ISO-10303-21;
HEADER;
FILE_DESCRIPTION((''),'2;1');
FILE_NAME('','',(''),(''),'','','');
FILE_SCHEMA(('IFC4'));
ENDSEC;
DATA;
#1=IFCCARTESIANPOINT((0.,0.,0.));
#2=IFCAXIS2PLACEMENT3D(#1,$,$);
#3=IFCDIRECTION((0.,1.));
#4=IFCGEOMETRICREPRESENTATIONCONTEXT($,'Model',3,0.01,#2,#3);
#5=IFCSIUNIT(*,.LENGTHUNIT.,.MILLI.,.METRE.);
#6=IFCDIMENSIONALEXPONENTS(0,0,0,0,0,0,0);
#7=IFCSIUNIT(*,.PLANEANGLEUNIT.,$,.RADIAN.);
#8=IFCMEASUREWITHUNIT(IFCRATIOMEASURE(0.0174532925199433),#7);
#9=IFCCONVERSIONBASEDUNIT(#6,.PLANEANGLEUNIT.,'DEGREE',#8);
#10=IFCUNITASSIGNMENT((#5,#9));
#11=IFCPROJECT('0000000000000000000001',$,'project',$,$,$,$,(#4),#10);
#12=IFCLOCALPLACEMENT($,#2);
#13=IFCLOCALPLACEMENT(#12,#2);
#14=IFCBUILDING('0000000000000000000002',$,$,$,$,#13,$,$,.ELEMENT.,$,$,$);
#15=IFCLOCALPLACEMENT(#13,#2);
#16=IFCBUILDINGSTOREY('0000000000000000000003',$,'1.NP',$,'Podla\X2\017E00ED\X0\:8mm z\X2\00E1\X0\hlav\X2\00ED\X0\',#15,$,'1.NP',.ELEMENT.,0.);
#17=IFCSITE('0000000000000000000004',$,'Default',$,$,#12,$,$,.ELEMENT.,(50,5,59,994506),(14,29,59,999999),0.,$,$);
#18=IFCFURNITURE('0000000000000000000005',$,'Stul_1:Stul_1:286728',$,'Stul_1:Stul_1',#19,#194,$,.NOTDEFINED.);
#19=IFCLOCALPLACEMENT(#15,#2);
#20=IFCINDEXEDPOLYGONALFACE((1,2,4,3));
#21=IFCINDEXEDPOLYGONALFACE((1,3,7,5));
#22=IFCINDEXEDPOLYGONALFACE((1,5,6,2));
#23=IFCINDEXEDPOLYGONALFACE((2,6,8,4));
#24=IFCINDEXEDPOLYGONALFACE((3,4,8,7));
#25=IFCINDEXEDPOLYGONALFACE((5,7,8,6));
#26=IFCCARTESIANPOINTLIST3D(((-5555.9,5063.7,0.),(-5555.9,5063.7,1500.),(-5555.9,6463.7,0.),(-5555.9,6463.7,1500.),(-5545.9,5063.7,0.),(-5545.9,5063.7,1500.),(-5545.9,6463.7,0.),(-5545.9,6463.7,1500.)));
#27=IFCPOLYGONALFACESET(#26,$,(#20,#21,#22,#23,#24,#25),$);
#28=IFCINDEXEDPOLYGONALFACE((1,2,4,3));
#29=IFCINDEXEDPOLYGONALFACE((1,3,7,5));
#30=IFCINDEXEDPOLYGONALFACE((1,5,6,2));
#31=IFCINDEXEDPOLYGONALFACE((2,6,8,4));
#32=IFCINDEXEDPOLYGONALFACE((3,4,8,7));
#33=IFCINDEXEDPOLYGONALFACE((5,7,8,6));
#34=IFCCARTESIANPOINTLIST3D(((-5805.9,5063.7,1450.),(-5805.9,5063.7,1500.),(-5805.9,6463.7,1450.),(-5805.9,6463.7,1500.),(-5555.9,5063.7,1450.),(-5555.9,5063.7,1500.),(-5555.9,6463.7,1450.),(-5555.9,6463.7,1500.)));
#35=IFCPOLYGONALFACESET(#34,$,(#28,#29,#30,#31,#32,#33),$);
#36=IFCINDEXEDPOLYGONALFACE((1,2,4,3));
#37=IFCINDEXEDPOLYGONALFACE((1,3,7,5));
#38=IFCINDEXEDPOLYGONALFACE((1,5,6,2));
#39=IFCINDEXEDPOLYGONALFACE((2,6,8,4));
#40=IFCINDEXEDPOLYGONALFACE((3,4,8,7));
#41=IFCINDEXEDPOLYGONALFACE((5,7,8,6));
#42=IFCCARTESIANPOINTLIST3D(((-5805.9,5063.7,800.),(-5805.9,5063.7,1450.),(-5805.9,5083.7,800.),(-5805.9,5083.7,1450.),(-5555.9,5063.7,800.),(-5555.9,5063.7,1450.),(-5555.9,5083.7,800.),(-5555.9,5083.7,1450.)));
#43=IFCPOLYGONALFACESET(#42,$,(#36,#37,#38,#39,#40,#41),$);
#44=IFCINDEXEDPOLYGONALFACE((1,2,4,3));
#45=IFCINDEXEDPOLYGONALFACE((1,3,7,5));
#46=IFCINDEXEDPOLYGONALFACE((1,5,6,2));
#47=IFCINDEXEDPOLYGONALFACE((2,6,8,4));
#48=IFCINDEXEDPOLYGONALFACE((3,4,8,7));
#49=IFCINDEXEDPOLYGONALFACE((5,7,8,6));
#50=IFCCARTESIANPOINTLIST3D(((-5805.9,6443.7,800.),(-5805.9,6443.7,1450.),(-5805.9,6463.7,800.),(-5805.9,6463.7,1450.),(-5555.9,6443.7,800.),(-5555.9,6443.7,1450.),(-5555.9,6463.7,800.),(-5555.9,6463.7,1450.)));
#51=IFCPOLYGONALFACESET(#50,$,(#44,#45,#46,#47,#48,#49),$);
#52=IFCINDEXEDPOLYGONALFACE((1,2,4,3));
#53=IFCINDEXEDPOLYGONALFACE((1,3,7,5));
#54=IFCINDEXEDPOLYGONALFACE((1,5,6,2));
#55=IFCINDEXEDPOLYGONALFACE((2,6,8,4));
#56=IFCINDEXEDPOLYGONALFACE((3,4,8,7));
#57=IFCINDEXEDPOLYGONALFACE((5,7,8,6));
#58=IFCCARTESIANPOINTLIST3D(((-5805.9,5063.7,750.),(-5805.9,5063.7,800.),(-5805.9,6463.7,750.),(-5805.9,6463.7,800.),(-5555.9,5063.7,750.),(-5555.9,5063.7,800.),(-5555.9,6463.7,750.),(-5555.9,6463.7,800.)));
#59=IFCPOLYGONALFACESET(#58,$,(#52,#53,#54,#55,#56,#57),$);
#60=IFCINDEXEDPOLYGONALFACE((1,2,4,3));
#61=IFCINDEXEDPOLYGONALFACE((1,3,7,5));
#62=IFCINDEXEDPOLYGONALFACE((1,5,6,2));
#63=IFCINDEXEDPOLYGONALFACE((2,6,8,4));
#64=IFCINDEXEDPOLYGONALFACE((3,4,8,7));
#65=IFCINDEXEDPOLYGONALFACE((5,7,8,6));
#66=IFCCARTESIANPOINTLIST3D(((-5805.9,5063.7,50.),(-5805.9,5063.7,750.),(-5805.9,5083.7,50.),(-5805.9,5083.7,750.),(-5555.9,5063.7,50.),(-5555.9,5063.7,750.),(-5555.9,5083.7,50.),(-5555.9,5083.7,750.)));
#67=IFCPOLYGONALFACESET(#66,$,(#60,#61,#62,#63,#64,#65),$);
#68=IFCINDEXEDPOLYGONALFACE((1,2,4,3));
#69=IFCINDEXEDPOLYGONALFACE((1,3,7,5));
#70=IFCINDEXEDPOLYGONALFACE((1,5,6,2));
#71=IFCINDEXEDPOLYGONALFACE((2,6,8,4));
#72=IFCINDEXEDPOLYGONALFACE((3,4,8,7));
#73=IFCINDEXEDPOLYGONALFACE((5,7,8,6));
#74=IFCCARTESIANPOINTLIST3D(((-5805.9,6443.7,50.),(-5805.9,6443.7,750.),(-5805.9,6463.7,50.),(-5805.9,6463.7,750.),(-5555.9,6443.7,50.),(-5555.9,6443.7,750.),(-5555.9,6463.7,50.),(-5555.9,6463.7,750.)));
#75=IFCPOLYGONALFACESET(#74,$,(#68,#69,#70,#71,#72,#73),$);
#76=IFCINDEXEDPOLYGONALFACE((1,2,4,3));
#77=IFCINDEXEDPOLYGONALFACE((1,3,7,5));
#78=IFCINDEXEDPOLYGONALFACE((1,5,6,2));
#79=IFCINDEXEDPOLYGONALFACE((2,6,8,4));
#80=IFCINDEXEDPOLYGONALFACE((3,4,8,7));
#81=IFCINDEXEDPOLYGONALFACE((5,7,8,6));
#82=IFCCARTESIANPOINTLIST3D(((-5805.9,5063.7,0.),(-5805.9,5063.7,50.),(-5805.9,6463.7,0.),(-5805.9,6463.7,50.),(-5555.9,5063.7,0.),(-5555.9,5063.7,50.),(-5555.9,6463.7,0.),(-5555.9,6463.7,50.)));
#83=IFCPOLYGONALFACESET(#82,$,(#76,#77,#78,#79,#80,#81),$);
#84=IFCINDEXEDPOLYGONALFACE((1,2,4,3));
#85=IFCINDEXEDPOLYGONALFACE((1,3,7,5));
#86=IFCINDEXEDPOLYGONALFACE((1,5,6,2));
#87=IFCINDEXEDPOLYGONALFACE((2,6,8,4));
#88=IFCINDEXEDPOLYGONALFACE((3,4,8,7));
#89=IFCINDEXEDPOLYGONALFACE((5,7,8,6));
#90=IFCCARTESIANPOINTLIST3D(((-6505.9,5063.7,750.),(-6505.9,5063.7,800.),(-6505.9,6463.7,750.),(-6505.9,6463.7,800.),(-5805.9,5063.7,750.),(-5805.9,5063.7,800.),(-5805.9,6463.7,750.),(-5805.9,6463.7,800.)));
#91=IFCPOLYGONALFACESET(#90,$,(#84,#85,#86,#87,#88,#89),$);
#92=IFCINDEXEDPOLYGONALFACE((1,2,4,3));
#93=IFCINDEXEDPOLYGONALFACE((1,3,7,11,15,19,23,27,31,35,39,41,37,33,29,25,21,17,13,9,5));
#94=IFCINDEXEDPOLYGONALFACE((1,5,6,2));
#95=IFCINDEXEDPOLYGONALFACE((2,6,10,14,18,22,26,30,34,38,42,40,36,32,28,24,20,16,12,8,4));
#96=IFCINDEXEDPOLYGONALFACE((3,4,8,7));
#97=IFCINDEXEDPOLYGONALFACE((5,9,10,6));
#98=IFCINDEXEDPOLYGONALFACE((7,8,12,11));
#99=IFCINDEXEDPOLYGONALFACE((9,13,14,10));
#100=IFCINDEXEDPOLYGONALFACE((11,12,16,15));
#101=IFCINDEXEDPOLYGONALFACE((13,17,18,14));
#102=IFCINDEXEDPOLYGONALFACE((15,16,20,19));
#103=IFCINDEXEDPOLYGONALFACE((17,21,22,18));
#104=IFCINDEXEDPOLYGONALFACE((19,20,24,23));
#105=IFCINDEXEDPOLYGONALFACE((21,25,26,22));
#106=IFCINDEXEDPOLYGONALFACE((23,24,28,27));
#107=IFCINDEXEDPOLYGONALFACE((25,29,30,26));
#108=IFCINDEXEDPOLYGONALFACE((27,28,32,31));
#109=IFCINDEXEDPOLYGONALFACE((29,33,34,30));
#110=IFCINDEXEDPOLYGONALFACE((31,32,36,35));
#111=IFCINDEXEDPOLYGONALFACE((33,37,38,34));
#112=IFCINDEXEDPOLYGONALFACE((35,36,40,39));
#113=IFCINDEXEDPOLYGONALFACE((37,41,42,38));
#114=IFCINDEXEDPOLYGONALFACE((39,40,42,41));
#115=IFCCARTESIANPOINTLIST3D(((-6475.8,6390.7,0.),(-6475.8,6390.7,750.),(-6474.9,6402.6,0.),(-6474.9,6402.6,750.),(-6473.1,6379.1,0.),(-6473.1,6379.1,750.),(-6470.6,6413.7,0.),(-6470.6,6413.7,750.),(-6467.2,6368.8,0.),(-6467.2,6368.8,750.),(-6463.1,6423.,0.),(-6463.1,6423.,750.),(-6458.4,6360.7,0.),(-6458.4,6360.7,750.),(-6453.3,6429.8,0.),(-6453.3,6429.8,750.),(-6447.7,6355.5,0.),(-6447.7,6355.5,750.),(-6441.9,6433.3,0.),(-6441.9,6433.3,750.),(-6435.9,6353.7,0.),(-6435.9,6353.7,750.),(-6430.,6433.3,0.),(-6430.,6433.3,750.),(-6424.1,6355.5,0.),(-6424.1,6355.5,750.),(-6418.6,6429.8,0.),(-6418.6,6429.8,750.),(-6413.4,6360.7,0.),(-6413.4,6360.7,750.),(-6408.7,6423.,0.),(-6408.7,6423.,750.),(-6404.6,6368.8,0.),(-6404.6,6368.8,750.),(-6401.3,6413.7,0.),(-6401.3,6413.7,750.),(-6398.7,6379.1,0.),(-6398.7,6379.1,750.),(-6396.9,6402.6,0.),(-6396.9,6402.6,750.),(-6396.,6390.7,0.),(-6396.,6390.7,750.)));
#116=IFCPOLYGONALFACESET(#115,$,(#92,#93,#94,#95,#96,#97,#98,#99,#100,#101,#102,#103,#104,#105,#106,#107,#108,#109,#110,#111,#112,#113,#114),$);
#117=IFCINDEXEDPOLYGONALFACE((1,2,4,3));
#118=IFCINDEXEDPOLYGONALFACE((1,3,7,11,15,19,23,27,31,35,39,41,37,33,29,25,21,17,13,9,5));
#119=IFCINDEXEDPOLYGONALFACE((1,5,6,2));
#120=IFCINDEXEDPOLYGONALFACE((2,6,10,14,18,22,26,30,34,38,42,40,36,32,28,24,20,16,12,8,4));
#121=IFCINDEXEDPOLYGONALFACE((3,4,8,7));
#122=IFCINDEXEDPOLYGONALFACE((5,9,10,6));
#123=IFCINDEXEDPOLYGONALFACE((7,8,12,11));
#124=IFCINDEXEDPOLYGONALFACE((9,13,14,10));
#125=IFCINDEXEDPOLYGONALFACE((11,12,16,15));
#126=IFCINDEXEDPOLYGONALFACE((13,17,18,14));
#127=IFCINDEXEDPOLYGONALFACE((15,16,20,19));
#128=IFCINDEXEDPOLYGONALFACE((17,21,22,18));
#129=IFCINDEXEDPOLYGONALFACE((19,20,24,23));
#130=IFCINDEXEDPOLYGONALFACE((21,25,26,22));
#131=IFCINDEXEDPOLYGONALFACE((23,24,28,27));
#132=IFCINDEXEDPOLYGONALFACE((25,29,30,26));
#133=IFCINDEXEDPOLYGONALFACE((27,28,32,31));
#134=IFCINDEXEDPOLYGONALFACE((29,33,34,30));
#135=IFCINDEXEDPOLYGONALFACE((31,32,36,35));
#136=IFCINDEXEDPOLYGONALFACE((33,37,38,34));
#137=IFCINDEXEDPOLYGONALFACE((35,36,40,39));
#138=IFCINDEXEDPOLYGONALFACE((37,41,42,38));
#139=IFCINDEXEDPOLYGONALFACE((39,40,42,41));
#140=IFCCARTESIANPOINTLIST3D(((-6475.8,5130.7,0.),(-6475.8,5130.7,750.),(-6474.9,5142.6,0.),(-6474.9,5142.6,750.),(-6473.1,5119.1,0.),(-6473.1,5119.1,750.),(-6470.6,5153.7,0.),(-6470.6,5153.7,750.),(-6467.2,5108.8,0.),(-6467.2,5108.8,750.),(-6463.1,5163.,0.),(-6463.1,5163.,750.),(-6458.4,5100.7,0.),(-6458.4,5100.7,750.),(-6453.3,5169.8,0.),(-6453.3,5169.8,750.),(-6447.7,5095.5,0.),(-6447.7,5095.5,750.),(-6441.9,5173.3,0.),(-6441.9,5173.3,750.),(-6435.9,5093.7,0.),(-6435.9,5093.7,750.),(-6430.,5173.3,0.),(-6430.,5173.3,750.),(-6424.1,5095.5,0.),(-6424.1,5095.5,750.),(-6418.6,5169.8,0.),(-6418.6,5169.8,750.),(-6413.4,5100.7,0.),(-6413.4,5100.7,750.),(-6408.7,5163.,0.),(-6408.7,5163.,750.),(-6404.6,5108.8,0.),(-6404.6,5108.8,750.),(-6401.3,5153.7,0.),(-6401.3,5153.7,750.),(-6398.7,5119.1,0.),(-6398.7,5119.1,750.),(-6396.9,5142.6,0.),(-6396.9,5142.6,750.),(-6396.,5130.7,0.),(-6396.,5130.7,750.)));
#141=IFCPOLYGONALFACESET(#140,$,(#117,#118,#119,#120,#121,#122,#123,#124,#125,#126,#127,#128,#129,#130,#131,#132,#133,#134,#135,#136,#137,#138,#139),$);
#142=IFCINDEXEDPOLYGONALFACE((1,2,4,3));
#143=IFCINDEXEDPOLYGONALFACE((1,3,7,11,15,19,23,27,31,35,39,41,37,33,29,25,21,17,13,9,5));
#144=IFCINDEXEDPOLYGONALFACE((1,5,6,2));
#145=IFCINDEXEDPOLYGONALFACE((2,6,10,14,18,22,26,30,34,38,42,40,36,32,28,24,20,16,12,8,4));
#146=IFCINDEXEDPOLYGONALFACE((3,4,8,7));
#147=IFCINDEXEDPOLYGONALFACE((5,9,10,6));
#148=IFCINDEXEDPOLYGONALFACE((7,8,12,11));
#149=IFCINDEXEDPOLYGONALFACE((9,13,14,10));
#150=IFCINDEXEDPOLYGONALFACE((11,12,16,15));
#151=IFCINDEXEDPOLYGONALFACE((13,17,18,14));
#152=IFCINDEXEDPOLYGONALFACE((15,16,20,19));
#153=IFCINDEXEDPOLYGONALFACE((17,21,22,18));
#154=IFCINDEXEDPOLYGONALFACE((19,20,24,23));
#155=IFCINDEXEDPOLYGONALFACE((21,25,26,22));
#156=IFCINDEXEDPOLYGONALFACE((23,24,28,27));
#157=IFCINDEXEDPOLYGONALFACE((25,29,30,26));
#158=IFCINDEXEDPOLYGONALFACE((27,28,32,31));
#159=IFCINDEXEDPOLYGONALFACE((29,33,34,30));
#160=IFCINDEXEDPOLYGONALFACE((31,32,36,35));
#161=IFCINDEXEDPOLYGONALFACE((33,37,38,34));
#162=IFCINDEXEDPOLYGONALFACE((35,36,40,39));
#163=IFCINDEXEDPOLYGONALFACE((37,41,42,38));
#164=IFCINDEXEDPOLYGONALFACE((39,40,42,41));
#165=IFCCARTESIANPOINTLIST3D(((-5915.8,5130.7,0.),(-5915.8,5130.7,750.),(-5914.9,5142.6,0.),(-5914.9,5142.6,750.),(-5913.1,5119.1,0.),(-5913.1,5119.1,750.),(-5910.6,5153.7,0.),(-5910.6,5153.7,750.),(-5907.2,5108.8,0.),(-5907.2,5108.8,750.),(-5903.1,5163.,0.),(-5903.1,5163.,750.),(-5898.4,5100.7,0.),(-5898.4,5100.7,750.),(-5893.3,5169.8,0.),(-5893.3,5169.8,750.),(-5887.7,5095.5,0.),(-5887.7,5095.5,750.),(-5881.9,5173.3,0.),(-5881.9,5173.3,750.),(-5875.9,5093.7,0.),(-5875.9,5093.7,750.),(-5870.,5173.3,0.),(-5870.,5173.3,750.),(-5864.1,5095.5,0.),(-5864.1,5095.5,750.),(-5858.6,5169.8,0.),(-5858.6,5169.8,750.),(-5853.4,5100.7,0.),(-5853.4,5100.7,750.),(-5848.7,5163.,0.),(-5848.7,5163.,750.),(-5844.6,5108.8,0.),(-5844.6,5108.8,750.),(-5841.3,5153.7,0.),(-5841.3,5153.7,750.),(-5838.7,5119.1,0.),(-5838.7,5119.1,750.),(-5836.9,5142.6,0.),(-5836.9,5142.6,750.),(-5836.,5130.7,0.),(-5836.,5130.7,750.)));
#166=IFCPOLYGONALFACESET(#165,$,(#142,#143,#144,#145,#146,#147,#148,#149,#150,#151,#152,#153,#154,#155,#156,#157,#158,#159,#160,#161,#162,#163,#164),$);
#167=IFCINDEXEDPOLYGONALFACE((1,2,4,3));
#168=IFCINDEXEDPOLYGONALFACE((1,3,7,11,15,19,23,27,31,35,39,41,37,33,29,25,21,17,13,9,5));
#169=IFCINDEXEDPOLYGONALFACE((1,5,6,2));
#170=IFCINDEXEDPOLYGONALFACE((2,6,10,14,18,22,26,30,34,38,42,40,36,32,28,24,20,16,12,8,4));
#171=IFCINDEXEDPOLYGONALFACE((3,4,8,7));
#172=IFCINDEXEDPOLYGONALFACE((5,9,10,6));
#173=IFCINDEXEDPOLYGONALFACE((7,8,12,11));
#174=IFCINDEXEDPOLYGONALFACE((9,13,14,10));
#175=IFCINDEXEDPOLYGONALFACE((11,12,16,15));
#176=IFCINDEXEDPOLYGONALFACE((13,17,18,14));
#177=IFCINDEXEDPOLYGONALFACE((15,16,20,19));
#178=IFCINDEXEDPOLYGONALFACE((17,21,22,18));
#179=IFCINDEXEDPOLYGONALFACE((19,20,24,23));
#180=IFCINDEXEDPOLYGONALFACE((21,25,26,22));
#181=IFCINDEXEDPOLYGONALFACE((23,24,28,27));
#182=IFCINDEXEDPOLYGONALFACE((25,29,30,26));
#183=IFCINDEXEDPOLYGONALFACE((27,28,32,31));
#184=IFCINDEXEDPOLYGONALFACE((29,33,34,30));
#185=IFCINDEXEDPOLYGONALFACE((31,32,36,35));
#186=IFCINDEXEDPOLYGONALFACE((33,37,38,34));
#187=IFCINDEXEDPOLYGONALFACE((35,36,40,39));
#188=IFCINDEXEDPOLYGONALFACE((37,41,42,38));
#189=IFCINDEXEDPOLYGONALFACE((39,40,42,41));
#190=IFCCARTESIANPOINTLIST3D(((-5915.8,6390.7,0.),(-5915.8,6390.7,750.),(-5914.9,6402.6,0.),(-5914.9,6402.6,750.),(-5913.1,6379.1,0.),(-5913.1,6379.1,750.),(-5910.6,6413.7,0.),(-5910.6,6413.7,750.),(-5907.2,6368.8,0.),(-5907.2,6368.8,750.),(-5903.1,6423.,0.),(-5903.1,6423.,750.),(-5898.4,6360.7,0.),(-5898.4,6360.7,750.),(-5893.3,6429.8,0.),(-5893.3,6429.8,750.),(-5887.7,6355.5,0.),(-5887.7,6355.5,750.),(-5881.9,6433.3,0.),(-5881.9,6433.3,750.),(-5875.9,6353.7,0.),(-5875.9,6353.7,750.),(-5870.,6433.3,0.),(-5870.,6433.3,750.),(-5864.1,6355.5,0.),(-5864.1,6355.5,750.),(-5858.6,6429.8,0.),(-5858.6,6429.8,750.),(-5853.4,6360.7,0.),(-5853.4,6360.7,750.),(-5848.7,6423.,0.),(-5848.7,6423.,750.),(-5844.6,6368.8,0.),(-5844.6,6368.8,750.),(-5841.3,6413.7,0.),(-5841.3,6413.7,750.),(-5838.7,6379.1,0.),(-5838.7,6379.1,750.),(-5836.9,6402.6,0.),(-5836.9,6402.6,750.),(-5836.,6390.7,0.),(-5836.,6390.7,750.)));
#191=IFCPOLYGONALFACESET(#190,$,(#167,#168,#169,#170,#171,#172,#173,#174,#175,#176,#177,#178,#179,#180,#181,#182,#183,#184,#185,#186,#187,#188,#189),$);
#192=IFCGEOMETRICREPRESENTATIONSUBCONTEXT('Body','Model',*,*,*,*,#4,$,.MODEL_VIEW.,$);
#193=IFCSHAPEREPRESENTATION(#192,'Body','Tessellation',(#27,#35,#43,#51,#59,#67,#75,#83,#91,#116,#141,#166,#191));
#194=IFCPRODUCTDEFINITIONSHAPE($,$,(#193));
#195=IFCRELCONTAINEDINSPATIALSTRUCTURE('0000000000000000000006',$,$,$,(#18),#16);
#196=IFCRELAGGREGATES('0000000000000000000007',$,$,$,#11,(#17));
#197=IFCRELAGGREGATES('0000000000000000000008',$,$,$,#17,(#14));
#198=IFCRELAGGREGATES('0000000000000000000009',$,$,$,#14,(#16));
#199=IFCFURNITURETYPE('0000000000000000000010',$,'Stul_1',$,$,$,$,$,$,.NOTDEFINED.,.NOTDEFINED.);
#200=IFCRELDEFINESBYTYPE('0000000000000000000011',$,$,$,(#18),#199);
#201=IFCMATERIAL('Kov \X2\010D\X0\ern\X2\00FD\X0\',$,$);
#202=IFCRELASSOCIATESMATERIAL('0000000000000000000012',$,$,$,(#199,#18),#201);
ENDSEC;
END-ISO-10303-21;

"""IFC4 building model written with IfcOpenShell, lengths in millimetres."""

from ifc_helpers import new_model, entity, si_unit, converted_unit, direction, frame, frame_2d, origin, origin_2d_with_axis, place, context, subcontext, project, spatial, rectangle, circle, extrude, source, transform, mapped, material, type_object, type_shapes, element, save


model = new_model("IFC4")

# Units and contexts
model_context = context("Model", 3, precision=0.01, world=origin(), true_north=direction((0.0, 1.0)))
body_context = subcontext(model_context, "Body", "Model", "MODEL_VIEW")
ifc_project = project(units=[si_unit("LENGTHUNIT", "METRE", prefix="MILLI"), converted_unit("PLANEANGLEUNIT", "DEGREE", entity("IfcRatioMeasure", 0.0174532925199433), si_unit("PLANEANGLEUNIT", "RADIAN"), dimensions=[0, 0, 0, 0, 0, 0, 0])], contexts=[model_context])

# Site, building, storey
site_placement = place(None, origin())
site = spatial("IfcSite", under=ifc_project, at=site_placement, Name="Default", CompositionType="ELEMENT", RefLatitude=(50, 5, 59, 994506), RefLongitude=(14, 29, 59, 999999), RefElevation=0.0)
building_placement = place(site_placement, origin())
building = spatial("IfcBuilding", under=site, at=building_placement, CompositionType="ELEMENT")
storey_placement = place(building_placement, origin())
storey = spatial("IfcBuildingStorey", under=building, at=storey_placement, Name="1.NP", ObjectType="Podlaží:8mm záhlaví", LongName="1.NP", CompositionType="ELEMENT", Elevation=0.0)

# Furniture
ifc_material_1 = material(Name="Kov černý")
furniture_type = type_object("IfcFurnitureType", Name="Stul_1", AssemblyPlace="NOTDEFINED", PredefinedType="NOTDEFINED", material=ifc_material_1)
shared_shape_1 = source(origin(), body_context, "Body", "SweptSolid", [
    extrude(rectangle(XDim=1400.0, YDim=10.0, at=origin_2d_with_axis()), frame((0.0, 605.0, 0.0), z_axis=(0.0, 0.0, 1.0), x_axis=(-1.0, 0.0, 0.0)), (0.0, 0.0, 1.0), 1500.0),
    extrude(rectangle(XDim=1400.0, YDim=250.0, at=frame_2d((0.0, 0.0), x_axis=(1.0, 0.0))), frame((0.0, 475.0, 1450.0), z_axis=(0.0, 0.0, 1.0), x_axis=(-1.0, 0.0, 0.0)), (0.0, 0.0, 1.0), 50.0),
    extrude(rectangle(XDim=20.0, YDim=250.0, at=origin_2d_with_axis()), frame((690.0, 475.0, 800.0), z_axis=(0.0, 0.0, 1.0), x_axis=(-1.0, 0.0, 0.0)), (0.0, 0.0, 1.0), 650.0),
    extrude(rectangle(XDim=20.0, YDim=250.0, at=frame_2d((0.0, 0.0), x_axis=(1.0, 0.0))), frame((-690.0, 475.0, 800.0), z_axis=(0.0, 0.0, 1.0), x_axis=(-1.0, 0.0, 0.0)), (0.0, 0.0, 1.0), 650.0),
    extrude(rectangle(XDim=1400.0, YDim=250.0, at=origin_2d_with_axis()), frame((0.0, 475.0, 750.0), z_axis=(0.0, 0.0, 1.0), x_axis=(-1.0, 0.0, 0.0)), (0.0, 0.0, 1.0), 50.0),
    extrude(rectangle(XDim=20.0, YDim=250.0, at=origin_2d_with_axis()), frame((690.0, 475.0, 50.0), z_axis=(0.0, 0.0, 1.0), x_axis=(-1.0, 0.0, 0.0)), (0.0, 0.0, 1.0), 700.0),
    extrude(rectangle(XDim=20.0, YDim=250.0, at=frame_2d((0.0, 0.0), x_axis=(1.0, 0.0))), frame((-690.0, 475.0, 50.0), z_axis=(0.0, 0.0, 1.0), x_axis=(-1.0, 0.0, 0.0)), (0.0, 0.0, 1.0), 700.0),
    extrude(rectangle(XDim=1400.0, YDim=250.0, at=origin_2d_with_axis()), frame((0.0, 475.0, 0.0), z_axis=(0.0, 0.0, 1.0), x_axis=(-1.0, 0.0, 0.0)), (0.0, 0.0, 1.0), 50.0),
    extrude(rectangle(XDim=1400.0, YDim=700.0, at=origin_2d_with_axis()), frame((0.0, 0.0, 750.0), z_axis=(0.0, 0.0, 1.0), x_axis=(-1.0, 0.0, 0.0)), (0.0, 0.0, 1.0), 50.0),
    extrude(circle(Radius=40.0, at=frame_2d((0.0, 0.0), x_axis=(1.0, 0.0))), frame((-630.0, -280.0, 0.0)), (0.0, 0.0, 1.0), 750.0),
    extrude(circle(Radius=40.0, at=frame_2d((0.0, 0.0), x_axis=(1.0, 0.0))), frame((630.0, -280.0, 0.0)), (0.0, 0.0, 1.0), 750.0),
    extrude(circle(Radius=40.0, at=frame_2d((0.0, 0.0), x_axis=(1.0, 0.0))), frame((630.0, 280.0, 0.0)), (0.0, 0.0, 1.0), 750.0),
    extrude(circle(Radius=40.0, at=frame_2d((0.0, 0.0), x_axis=(1.0, 0.0))), frame((-630.0, 280.0, 0.0)), (0.0, 0.0, 1.0), 750.0),
])
type_shapes(furniture_type, [shared_shape_1])
for number, where, z_axis, x_axis, name in (
    (1, (-6155.9, 5763.7, 0.0), (0.0, 0.0, 1.0), (0.0, -1.0, 0.0), "Stul_1:Stul_1:286728"),
):
    element("IfcFurniture", number, at=place(storey_placement, frame(where, z_axis=z_axis, x_axis=x_axis)), inside=storey, type_object=furniture_type, material=ifc_material_1, Name=name, ObjectType="Stul_1:Stul_1", PredefinedType="NOTDEFINED", context=body_context, shape_type="MappedRepresentation", body=[
        mapped(shared_shape_1, transform((0.0, 0.0, 0.0), scale=1.0)),
    ])

save(model, "model.ifc")
